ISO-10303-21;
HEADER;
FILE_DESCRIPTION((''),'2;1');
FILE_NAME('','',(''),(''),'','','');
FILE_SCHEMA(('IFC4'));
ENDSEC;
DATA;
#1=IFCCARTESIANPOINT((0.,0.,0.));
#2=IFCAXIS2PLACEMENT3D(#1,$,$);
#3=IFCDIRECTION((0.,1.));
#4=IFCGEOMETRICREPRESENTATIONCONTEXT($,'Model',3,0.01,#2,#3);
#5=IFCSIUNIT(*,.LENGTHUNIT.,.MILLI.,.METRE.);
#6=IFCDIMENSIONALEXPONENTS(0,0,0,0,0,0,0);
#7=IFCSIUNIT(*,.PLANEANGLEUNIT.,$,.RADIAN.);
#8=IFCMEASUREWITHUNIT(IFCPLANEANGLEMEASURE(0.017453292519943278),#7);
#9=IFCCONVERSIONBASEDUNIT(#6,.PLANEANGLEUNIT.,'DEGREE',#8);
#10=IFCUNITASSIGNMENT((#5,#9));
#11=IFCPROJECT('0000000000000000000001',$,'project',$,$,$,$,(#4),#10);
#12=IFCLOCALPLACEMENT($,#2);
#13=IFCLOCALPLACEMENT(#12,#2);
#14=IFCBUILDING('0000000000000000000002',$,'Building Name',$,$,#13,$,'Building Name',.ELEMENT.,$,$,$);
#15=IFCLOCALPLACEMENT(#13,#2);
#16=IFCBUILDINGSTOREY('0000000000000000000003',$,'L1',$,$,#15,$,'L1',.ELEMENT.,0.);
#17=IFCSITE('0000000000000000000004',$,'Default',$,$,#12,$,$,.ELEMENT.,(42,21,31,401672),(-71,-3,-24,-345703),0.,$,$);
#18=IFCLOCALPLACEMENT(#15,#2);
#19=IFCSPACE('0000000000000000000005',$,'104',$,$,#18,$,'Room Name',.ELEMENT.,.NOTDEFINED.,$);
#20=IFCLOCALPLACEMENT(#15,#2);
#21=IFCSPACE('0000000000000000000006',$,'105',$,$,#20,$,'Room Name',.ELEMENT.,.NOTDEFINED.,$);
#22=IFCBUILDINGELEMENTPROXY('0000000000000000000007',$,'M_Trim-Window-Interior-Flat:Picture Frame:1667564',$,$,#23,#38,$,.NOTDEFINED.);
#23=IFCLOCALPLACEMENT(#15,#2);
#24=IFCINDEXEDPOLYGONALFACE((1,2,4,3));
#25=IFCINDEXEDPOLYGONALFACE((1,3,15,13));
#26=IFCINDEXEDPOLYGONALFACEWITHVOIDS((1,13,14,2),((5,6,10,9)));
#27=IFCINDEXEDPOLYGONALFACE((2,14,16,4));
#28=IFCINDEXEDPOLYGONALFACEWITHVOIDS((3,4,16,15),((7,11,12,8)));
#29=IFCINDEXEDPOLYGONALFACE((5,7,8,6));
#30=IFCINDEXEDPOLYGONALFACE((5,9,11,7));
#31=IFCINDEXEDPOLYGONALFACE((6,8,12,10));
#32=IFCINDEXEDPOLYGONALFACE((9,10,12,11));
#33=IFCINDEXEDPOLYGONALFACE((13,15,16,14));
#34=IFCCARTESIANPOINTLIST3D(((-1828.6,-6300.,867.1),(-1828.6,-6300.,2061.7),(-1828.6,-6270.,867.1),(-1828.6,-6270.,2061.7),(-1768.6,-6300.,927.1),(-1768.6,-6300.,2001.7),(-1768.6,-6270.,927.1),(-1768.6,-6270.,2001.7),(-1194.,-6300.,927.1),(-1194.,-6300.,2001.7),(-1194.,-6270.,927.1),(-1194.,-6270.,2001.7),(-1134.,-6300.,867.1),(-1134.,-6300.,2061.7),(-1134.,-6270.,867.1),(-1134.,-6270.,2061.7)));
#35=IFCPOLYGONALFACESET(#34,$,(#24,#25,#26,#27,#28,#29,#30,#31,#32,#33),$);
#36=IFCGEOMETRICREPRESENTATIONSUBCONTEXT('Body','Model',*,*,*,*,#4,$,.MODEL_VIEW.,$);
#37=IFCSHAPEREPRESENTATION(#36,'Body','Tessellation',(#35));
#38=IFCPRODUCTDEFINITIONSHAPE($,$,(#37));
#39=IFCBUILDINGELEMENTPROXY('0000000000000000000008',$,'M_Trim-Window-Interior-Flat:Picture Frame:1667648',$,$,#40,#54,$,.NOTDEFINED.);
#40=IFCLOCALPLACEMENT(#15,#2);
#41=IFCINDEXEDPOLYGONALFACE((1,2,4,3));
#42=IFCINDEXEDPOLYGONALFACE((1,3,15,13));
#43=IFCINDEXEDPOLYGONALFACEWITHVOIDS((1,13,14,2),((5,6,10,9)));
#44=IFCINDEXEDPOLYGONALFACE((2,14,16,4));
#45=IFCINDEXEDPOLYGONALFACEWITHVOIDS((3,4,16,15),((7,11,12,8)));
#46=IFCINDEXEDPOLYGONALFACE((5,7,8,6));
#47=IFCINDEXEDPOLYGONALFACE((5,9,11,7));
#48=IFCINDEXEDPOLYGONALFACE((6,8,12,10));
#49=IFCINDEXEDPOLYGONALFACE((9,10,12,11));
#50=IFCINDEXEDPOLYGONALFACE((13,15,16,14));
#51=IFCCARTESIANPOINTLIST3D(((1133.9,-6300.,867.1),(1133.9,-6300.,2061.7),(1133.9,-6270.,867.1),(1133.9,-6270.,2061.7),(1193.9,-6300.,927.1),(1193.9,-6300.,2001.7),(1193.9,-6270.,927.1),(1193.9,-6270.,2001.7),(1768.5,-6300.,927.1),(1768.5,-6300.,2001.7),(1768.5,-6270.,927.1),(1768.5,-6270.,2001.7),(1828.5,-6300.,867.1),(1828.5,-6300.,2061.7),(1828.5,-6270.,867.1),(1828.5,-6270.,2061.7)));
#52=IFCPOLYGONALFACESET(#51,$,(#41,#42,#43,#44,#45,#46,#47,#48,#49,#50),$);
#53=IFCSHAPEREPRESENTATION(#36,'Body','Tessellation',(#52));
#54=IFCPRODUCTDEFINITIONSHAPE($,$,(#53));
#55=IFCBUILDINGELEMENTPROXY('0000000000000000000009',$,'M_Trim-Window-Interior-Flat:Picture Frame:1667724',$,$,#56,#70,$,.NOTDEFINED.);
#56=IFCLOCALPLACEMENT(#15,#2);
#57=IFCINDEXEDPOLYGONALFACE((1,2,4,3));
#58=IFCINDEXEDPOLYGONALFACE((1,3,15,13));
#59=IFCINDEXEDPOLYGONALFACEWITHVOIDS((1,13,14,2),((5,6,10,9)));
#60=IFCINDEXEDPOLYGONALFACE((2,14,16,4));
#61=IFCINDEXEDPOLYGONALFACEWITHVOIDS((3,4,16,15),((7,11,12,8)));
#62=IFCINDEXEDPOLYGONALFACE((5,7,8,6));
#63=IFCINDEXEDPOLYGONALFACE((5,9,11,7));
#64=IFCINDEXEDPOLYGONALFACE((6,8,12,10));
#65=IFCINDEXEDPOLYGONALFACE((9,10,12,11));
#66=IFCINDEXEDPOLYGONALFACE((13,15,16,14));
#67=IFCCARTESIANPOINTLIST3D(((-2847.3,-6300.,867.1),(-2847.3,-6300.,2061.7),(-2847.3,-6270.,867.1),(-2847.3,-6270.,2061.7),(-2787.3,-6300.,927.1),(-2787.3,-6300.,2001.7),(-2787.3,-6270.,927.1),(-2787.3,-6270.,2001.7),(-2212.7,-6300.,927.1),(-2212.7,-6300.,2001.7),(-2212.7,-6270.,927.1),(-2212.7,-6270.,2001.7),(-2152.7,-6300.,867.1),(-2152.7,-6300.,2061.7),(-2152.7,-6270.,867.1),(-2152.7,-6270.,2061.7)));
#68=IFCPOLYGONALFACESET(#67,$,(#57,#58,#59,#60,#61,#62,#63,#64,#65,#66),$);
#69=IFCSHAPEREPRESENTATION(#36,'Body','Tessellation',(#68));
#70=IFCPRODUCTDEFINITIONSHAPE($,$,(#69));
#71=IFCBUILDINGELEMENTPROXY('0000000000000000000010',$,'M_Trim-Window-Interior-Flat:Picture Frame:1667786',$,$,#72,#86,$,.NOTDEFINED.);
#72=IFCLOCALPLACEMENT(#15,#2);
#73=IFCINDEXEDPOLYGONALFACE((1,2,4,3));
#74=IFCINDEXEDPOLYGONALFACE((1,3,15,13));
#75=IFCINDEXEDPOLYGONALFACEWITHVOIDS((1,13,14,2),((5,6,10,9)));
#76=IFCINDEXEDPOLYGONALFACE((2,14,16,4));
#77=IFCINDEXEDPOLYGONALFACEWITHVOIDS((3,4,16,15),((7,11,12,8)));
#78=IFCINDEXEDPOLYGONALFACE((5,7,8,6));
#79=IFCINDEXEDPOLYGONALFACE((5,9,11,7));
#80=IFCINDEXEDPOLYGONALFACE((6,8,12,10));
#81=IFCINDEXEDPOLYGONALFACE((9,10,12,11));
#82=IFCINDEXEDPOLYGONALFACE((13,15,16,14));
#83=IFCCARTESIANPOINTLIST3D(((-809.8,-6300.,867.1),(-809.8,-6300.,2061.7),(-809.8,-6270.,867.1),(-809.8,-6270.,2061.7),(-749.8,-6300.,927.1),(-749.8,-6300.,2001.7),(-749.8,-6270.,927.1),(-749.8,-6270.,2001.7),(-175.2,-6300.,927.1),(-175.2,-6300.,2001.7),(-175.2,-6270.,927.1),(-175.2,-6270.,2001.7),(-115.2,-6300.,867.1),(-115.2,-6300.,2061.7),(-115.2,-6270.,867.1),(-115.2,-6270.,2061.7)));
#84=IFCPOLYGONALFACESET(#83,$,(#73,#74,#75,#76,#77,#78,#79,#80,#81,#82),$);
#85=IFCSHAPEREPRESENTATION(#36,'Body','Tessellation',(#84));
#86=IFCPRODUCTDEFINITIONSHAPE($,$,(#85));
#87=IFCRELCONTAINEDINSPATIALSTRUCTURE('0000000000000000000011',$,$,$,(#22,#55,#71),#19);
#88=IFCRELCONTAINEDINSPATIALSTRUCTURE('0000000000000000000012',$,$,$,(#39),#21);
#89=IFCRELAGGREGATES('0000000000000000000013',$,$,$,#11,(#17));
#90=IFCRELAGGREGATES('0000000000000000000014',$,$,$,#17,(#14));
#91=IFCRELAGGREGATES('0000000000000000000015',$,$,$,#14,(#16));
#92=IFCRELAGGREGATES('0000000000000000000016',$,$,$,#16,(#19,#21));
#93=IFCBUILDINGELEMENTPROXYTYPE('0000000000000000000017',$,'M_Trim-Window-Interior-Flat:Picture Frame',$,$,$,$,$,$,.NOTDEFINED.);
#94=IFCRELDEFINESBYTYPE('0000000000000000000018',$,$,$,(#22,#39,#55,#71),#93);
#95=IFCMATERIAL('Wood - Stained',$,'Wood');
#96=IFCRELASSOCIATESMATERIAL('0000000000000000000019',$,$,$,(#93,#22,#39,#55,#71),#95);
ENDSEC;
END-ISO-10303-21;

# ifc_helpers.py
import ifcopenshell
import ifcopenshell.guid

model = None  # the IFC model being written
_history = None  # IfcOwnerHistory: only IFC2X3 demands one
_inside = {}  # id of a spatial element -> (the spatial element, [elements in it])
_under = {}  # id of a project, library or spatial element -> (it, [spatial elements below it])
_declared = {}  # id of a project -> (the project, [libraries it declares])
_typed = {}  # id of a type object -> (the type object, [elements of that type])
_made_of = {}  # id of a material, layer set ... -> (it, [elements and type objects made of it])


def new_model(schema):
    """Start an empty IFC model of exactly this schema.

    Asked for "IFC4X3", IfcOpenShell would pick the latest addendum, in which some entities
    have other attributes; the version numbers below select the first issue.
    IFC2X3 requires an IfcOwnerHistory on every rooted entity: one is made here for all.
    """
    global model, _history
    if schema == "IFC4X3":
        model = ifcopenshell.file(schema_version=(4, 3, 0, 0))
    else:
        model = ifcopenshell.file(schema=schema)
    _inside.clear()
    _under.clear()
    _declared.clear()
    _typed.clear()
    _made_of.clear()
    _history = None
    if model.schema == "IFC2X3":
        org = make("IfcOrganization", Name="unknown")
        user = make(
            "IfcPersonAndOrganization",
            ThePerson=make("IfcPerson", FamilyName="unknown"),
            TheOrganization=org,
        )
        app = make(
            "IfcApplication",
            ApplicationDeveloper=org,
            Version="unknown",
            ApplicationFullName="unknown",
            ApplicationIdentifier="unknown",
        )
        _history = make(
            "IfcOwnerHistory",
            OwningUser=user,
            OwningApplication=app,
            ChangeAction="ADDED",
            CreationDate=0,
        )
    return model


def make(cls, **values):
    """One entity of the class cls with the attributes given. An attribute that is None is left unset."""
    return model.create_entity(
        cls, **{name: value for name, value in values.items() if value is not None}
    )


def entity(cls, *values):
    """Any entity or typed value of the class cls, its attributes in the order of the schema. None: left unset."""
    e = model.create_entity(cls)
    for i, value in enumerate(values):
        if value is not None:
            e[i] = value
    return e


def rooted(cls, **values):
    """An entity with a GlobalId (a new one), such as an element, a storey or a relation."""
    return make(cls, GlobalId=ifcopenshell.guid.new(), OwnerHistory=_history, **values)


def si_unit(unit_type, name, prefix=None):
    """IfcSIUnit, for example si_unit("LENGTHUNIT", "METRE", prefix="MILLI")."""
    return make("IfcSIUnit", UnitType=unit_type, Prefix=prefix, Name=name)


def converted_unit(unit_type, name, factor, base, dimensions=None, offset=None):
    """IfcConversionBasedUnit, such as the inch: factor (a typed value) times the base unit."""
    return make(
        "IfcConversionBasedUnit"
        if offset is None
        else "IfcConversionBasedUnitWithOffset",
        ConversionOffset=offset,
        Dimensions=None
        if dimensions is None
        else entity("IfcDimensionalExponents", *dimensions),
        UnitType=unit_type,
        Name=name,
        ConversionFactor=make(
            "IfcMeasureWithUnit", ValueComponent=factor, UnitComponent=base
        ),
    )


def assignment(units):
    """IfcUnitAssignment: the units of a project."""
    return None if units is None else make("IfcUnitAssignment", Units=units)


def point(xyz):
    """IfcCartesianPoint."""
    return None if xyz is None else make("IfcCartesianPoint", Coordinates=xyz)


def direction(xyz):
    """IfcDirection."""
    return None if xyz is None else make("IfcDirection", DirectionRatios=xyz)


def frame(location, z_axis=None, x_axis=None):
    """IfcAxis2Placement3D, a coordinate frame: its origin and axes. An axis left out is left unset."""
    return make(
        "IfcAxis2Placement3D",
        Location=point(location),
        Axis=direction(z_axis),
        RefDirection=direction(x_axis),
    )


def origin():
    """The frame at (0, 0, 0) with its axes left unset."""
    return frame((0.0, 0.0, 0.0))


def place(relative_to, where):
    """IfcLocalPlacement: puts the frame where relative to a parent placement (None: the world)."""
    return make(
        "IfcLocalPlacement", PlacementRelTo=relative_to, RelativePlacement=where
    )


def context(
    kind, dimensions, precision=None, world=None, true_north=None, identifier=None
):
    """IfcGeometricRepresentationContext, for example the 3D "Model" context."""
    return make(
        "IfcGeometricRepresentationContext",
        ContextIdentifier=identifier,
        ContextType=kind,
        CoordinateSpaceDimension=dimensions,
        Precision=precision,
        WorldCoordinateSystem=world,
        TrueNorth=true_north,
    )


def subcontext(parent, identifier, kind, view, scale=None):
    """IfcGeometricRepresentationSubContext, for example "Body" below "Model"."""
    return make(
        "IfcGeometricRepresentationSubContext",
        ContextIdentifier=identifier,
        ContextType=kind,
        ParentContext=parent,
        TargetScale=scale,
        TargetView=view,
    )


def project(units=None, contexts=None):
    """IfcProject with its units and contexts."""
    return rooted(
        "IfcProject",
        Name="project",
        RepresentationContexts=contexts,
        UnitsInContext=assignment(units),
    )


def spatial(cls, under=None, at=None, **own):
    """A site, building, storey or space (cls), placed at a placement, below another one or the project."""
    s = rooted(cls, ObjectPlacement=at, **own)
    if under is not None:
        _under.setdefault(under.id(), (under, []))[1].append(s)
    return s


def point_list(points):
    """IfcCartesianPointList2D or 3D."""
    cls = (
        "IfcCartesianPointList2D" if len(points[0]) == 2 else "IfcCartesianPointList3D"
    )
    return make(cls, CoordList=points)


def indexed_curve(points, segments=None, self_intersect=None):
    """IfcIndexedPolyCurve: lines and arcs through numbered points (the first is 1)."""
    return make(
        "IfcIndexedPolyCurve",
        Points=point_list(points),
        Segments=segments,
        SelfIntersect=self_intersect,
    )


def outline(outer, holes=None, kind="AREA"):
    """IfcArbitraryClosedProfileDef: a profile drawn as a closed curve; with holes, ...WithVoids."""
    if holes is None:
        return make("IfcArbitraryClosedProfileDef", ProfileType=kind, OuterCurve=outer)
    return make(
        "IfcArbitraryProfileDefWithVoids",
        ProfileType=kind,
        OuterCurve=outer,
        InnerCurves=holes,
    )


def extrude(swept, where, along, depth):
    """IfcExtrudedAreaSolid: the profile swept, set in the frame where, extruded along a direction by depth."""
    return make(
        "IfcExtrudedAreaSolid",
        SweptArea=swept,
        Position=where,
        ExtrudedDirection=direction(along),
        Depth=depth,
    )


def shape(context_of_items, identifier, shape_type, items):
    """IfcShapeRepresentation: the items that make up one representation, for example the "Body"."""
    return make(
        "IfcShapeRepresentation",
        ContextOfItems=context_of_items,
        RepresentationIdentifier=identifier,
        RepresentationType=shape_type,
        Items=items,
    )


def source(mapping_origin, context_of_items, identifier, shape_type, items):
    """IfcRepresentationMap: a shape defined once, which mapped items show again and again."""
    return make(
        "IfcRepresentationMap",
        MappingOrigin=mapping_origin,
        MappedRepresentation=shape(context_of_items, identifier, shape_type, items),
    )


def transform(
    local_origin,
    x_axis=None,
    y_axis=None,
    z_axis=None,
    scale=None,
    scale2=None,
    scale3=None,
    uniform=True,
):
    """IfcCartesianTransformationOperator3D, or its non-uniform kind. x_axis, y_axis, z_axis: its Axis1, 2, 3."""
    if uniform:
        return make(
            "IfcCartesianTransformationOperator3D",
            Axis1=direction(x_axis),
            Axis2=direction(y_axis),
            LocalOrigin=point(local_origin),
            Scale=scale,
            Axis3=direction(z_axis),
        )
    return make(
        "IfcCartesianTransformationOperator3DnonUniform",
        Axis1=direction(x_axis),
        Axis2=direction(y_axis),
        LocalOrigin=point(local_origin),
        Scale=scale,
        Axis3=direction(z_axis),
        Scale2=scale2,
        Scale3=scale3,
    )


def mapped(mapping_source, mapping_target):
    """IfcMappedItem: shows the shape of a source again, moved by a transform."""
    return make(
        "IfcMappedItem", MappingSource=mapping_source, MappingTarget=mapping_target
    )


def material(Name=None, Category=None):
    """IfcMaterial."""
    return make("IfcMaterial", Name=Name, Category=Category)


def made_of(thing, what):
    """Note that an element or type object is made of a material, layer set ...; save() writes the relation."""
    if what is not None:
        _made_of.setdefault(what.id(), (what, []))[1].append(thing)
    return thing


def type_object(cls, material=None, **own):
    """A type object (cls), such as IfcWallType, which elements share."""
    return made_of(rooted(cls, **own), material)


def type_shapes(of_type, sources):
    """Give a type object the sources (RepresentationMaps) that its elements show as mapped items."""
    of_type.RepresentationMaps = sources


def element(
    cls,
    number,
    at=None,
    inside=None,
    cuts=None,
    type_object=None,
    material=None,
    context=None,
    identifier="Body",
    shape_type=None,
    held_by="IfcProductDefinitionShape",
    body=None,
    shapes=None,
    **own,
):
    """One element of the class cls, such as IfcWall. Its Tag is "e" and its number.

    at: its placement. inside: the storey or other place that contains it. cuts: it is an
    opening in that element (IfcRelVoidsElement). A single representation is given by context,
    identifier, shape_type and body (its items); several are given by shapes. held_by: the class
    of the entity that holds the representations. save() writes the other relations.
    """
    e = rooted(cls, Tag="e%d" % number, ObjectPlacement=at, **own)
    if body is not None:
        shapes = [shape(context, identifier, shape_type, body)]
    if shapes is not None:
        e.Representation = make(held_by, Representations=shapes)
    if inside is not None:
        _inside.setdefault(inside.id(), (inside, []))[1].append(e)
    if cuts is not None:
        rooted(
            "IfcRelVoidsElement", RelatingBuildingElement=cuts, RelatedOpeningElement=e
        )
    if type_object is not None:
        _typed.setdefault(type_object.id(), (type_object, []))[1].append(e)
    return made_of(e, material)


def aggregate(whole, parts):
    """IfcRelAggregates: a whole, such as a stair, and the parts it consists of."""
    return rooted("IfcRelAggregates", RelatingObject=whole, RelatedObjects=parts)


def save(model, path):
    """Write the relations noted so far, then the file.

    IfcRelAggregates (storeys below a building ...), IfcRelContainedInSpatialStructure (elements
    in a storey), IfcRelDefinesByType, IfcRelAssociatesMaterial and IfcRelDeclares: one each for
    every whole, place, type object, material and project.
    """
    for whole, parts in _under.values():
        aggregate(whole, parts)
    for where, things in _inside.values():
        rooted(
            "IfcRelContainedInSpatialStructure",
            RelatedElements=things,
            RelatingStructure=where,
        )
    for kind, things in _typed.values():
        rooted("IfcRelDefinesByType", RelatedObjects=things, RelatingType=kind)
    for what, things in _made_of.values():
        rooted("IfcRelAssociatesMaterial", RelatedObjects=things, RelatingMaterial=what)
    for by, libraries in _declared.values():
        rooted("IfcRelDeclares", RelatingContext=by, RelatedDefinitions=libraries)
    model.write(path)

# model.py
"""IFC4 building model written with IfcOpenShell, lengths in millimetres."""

from ifc_helpers import new_model, entity, si_unit, converted_unit, direction, frame, origin, place, context, subcontext, project, spatial, indexed_curve, outline, extrude, source, transform, mapped, material, type_object, type_shapes, element, save


model = new_model("IFC4")

# Units and contexts
model_context = context("Model", 3, precision=0.01, world=origin(), true_north=direction((0.0, 1.0)))
body_context = subcontext(model_context, "Body", "Model", "MODEL_VIEW")
ifc_project = project(units=[si_unit("LENGTHUNIT", "METRE", prefix="MILLI"), converted_unit("PLANEANGLEUNIT", "DEGREE", entity("IfcPlaneAngleMeasure", 0.017453292519943278), si_unit("PLANEANGLEUNIT", "RADIAN"), dimensions=[0, 0, 0, 0, 0, 0, 0])], contexts=[model_context])

# Site, building, storey
site_placement = place(None, origin())
site = spatial("IfcSite", under=ifc_project, at=site_placement, Name="Default", CompositionType="ELEMENT", RefLatitude=(42, 21, 31, 401672), RefLongitude=(-71, -3, -24, -345703), RefElevation=0.0)
building_placement = place(site_placement, origin())
building = spatial("IfcBuilding", under=site, at=building_placement, Name="Building Name", LongName="Building Name", CompositionType="ELEMENT")
storey_placement = place(building_placement, origin())
storey = spatial("IfcBuildingStorey", under=building, at=storey_placement, Name="L1", LongName="L1", CompositionType="ELEMENT", Elevation=0.0)

# Shared definitions
ifc_material_1 = material(Name="Wood - Stained", Category="Wood")

# Shared definitions
space_1_placement = place(storey_placement, origin())
space_1 = spatial("IfcSpace", under=storey, at=space_1_placement, Name="104", LongName="Room Name", CompositionType="ELEMENT", PredefinedType="NOTDEFINED")

# Building element proxy
building_element_proxy_type_1 = type_object("IfcBuildingElementProxyType", Name="M_Trim-Window-Interior-Flat:Picture Frame", PredefinedType="NOTDEFINED", material=ifc_material_1)
shared_shape_1 = source(origin(), body_context, "Body", "SweptSolid", [
    extrude(outline(indexed_curve([(-347.3, -597.3), (347.3, -597.3), (347.3, 597.3), (-347.3, 597.3), (-347.3, -597.3)], self_intersect=False), holes=[indexed_curve([(-287.3, -537.3), (-287.3, 537.3), (287.3, 537.3), (287.3, -537.3), (-287.3, -537.3)], self_intersect=False)]), frame((0.0, -550.0, 0.0), z_axis=(0.0, 0.0, 1.0), x_axis=(-1.0, 0.0, 0.0)), (0.0, 0.0, 1.0), 30.0),
])
type_shapes(building_element_proxy_type_1, [shared_shape_1])
proxy_1_placement = place(space_1_placement, frame((-1481.3, -6300.0, 2014.4), z_axis=(0.0, 1.0, 0.0), x_axis=(-1.0, 0.0, 0.0)))
element("IfcBuildingElementProxy", 1, at=proxy_1_placement, inside=space_1, type_object=building_element_proxy_type_1, material=ifc_material_1, Name="M_Trim-Window-Interior-Flat:Picture Frame:1667564", PredefinedType="NOTDEFINED", context=body_context, shape_type="MappedRepresentation", body=[
    mapped(shared_shape_1, transform((0.0, 0.0, 0.0), scale=1.0)),
])

# Shared definitions
space_2_placement = place(storey_placement, origin())
space_2 = spatial("IfcSpace", under=storey, at=space_2_placement, Name="105", LongName="Room Name", CompositionType="ELEMENT", PredefinedType="NOTDEFINED")

# Building element proxies
proxy_2_placement = place(space_2_placement, frame((1481.2, -6300.0, 2014.4), z_axis=(0.0, 1.0, 0.0), x_axis=(-1.0, 0.0, 0.0)))
element("IfcBuildingElementProxy", 2, at=proxy_2_placement, inside=space_2, type_object=building_element_proxy_type_1, material=ifc_material_1, Name="M_Trim-Window-Interior-Flat:Picture Frame:1667648", PredefinedType="NOTDEFINED", context=body_context, shape_type="MappedRepresentation", body=[
    mapped(shared_shape_1, transform((0.0, 0.0, 0.0), scale=1.0)),
])
for number, where, z_axis, x_axis, name in (
    (3, (-2500.0, -6300.0, 2014.4), (0.0, 1.0, 0.0), (-1.0, 0.0, 0.0), "M_Trim-Window-Interior-Flat:Picture Frame:1667724"),
    (4, (-462.5, -6300.0, 2014.4), (0.0, 1.0, 0.0), (-1.0, 0.0, 0.0), "M_Trim-Window-Interior-Flat:Picture Frame:1667786"),
):
    element("IfcBuildingElementProxy", number, at=place(space_1_placement, frame(where, z_axis=z_axis, x_axis=x_axis)), inside=space_1, type_object=building_element_proxy_type_1, material=ifc_material_1, Name=name, PredefinedType="NOTDEFINED", context=body_context, shape_type="MappedRepresentation", body=[
        mapped(shared_shape_1, transform((0.0, 0.0, 0.0), scale=1.0)),
    ])

save(model, "model.ifc")
